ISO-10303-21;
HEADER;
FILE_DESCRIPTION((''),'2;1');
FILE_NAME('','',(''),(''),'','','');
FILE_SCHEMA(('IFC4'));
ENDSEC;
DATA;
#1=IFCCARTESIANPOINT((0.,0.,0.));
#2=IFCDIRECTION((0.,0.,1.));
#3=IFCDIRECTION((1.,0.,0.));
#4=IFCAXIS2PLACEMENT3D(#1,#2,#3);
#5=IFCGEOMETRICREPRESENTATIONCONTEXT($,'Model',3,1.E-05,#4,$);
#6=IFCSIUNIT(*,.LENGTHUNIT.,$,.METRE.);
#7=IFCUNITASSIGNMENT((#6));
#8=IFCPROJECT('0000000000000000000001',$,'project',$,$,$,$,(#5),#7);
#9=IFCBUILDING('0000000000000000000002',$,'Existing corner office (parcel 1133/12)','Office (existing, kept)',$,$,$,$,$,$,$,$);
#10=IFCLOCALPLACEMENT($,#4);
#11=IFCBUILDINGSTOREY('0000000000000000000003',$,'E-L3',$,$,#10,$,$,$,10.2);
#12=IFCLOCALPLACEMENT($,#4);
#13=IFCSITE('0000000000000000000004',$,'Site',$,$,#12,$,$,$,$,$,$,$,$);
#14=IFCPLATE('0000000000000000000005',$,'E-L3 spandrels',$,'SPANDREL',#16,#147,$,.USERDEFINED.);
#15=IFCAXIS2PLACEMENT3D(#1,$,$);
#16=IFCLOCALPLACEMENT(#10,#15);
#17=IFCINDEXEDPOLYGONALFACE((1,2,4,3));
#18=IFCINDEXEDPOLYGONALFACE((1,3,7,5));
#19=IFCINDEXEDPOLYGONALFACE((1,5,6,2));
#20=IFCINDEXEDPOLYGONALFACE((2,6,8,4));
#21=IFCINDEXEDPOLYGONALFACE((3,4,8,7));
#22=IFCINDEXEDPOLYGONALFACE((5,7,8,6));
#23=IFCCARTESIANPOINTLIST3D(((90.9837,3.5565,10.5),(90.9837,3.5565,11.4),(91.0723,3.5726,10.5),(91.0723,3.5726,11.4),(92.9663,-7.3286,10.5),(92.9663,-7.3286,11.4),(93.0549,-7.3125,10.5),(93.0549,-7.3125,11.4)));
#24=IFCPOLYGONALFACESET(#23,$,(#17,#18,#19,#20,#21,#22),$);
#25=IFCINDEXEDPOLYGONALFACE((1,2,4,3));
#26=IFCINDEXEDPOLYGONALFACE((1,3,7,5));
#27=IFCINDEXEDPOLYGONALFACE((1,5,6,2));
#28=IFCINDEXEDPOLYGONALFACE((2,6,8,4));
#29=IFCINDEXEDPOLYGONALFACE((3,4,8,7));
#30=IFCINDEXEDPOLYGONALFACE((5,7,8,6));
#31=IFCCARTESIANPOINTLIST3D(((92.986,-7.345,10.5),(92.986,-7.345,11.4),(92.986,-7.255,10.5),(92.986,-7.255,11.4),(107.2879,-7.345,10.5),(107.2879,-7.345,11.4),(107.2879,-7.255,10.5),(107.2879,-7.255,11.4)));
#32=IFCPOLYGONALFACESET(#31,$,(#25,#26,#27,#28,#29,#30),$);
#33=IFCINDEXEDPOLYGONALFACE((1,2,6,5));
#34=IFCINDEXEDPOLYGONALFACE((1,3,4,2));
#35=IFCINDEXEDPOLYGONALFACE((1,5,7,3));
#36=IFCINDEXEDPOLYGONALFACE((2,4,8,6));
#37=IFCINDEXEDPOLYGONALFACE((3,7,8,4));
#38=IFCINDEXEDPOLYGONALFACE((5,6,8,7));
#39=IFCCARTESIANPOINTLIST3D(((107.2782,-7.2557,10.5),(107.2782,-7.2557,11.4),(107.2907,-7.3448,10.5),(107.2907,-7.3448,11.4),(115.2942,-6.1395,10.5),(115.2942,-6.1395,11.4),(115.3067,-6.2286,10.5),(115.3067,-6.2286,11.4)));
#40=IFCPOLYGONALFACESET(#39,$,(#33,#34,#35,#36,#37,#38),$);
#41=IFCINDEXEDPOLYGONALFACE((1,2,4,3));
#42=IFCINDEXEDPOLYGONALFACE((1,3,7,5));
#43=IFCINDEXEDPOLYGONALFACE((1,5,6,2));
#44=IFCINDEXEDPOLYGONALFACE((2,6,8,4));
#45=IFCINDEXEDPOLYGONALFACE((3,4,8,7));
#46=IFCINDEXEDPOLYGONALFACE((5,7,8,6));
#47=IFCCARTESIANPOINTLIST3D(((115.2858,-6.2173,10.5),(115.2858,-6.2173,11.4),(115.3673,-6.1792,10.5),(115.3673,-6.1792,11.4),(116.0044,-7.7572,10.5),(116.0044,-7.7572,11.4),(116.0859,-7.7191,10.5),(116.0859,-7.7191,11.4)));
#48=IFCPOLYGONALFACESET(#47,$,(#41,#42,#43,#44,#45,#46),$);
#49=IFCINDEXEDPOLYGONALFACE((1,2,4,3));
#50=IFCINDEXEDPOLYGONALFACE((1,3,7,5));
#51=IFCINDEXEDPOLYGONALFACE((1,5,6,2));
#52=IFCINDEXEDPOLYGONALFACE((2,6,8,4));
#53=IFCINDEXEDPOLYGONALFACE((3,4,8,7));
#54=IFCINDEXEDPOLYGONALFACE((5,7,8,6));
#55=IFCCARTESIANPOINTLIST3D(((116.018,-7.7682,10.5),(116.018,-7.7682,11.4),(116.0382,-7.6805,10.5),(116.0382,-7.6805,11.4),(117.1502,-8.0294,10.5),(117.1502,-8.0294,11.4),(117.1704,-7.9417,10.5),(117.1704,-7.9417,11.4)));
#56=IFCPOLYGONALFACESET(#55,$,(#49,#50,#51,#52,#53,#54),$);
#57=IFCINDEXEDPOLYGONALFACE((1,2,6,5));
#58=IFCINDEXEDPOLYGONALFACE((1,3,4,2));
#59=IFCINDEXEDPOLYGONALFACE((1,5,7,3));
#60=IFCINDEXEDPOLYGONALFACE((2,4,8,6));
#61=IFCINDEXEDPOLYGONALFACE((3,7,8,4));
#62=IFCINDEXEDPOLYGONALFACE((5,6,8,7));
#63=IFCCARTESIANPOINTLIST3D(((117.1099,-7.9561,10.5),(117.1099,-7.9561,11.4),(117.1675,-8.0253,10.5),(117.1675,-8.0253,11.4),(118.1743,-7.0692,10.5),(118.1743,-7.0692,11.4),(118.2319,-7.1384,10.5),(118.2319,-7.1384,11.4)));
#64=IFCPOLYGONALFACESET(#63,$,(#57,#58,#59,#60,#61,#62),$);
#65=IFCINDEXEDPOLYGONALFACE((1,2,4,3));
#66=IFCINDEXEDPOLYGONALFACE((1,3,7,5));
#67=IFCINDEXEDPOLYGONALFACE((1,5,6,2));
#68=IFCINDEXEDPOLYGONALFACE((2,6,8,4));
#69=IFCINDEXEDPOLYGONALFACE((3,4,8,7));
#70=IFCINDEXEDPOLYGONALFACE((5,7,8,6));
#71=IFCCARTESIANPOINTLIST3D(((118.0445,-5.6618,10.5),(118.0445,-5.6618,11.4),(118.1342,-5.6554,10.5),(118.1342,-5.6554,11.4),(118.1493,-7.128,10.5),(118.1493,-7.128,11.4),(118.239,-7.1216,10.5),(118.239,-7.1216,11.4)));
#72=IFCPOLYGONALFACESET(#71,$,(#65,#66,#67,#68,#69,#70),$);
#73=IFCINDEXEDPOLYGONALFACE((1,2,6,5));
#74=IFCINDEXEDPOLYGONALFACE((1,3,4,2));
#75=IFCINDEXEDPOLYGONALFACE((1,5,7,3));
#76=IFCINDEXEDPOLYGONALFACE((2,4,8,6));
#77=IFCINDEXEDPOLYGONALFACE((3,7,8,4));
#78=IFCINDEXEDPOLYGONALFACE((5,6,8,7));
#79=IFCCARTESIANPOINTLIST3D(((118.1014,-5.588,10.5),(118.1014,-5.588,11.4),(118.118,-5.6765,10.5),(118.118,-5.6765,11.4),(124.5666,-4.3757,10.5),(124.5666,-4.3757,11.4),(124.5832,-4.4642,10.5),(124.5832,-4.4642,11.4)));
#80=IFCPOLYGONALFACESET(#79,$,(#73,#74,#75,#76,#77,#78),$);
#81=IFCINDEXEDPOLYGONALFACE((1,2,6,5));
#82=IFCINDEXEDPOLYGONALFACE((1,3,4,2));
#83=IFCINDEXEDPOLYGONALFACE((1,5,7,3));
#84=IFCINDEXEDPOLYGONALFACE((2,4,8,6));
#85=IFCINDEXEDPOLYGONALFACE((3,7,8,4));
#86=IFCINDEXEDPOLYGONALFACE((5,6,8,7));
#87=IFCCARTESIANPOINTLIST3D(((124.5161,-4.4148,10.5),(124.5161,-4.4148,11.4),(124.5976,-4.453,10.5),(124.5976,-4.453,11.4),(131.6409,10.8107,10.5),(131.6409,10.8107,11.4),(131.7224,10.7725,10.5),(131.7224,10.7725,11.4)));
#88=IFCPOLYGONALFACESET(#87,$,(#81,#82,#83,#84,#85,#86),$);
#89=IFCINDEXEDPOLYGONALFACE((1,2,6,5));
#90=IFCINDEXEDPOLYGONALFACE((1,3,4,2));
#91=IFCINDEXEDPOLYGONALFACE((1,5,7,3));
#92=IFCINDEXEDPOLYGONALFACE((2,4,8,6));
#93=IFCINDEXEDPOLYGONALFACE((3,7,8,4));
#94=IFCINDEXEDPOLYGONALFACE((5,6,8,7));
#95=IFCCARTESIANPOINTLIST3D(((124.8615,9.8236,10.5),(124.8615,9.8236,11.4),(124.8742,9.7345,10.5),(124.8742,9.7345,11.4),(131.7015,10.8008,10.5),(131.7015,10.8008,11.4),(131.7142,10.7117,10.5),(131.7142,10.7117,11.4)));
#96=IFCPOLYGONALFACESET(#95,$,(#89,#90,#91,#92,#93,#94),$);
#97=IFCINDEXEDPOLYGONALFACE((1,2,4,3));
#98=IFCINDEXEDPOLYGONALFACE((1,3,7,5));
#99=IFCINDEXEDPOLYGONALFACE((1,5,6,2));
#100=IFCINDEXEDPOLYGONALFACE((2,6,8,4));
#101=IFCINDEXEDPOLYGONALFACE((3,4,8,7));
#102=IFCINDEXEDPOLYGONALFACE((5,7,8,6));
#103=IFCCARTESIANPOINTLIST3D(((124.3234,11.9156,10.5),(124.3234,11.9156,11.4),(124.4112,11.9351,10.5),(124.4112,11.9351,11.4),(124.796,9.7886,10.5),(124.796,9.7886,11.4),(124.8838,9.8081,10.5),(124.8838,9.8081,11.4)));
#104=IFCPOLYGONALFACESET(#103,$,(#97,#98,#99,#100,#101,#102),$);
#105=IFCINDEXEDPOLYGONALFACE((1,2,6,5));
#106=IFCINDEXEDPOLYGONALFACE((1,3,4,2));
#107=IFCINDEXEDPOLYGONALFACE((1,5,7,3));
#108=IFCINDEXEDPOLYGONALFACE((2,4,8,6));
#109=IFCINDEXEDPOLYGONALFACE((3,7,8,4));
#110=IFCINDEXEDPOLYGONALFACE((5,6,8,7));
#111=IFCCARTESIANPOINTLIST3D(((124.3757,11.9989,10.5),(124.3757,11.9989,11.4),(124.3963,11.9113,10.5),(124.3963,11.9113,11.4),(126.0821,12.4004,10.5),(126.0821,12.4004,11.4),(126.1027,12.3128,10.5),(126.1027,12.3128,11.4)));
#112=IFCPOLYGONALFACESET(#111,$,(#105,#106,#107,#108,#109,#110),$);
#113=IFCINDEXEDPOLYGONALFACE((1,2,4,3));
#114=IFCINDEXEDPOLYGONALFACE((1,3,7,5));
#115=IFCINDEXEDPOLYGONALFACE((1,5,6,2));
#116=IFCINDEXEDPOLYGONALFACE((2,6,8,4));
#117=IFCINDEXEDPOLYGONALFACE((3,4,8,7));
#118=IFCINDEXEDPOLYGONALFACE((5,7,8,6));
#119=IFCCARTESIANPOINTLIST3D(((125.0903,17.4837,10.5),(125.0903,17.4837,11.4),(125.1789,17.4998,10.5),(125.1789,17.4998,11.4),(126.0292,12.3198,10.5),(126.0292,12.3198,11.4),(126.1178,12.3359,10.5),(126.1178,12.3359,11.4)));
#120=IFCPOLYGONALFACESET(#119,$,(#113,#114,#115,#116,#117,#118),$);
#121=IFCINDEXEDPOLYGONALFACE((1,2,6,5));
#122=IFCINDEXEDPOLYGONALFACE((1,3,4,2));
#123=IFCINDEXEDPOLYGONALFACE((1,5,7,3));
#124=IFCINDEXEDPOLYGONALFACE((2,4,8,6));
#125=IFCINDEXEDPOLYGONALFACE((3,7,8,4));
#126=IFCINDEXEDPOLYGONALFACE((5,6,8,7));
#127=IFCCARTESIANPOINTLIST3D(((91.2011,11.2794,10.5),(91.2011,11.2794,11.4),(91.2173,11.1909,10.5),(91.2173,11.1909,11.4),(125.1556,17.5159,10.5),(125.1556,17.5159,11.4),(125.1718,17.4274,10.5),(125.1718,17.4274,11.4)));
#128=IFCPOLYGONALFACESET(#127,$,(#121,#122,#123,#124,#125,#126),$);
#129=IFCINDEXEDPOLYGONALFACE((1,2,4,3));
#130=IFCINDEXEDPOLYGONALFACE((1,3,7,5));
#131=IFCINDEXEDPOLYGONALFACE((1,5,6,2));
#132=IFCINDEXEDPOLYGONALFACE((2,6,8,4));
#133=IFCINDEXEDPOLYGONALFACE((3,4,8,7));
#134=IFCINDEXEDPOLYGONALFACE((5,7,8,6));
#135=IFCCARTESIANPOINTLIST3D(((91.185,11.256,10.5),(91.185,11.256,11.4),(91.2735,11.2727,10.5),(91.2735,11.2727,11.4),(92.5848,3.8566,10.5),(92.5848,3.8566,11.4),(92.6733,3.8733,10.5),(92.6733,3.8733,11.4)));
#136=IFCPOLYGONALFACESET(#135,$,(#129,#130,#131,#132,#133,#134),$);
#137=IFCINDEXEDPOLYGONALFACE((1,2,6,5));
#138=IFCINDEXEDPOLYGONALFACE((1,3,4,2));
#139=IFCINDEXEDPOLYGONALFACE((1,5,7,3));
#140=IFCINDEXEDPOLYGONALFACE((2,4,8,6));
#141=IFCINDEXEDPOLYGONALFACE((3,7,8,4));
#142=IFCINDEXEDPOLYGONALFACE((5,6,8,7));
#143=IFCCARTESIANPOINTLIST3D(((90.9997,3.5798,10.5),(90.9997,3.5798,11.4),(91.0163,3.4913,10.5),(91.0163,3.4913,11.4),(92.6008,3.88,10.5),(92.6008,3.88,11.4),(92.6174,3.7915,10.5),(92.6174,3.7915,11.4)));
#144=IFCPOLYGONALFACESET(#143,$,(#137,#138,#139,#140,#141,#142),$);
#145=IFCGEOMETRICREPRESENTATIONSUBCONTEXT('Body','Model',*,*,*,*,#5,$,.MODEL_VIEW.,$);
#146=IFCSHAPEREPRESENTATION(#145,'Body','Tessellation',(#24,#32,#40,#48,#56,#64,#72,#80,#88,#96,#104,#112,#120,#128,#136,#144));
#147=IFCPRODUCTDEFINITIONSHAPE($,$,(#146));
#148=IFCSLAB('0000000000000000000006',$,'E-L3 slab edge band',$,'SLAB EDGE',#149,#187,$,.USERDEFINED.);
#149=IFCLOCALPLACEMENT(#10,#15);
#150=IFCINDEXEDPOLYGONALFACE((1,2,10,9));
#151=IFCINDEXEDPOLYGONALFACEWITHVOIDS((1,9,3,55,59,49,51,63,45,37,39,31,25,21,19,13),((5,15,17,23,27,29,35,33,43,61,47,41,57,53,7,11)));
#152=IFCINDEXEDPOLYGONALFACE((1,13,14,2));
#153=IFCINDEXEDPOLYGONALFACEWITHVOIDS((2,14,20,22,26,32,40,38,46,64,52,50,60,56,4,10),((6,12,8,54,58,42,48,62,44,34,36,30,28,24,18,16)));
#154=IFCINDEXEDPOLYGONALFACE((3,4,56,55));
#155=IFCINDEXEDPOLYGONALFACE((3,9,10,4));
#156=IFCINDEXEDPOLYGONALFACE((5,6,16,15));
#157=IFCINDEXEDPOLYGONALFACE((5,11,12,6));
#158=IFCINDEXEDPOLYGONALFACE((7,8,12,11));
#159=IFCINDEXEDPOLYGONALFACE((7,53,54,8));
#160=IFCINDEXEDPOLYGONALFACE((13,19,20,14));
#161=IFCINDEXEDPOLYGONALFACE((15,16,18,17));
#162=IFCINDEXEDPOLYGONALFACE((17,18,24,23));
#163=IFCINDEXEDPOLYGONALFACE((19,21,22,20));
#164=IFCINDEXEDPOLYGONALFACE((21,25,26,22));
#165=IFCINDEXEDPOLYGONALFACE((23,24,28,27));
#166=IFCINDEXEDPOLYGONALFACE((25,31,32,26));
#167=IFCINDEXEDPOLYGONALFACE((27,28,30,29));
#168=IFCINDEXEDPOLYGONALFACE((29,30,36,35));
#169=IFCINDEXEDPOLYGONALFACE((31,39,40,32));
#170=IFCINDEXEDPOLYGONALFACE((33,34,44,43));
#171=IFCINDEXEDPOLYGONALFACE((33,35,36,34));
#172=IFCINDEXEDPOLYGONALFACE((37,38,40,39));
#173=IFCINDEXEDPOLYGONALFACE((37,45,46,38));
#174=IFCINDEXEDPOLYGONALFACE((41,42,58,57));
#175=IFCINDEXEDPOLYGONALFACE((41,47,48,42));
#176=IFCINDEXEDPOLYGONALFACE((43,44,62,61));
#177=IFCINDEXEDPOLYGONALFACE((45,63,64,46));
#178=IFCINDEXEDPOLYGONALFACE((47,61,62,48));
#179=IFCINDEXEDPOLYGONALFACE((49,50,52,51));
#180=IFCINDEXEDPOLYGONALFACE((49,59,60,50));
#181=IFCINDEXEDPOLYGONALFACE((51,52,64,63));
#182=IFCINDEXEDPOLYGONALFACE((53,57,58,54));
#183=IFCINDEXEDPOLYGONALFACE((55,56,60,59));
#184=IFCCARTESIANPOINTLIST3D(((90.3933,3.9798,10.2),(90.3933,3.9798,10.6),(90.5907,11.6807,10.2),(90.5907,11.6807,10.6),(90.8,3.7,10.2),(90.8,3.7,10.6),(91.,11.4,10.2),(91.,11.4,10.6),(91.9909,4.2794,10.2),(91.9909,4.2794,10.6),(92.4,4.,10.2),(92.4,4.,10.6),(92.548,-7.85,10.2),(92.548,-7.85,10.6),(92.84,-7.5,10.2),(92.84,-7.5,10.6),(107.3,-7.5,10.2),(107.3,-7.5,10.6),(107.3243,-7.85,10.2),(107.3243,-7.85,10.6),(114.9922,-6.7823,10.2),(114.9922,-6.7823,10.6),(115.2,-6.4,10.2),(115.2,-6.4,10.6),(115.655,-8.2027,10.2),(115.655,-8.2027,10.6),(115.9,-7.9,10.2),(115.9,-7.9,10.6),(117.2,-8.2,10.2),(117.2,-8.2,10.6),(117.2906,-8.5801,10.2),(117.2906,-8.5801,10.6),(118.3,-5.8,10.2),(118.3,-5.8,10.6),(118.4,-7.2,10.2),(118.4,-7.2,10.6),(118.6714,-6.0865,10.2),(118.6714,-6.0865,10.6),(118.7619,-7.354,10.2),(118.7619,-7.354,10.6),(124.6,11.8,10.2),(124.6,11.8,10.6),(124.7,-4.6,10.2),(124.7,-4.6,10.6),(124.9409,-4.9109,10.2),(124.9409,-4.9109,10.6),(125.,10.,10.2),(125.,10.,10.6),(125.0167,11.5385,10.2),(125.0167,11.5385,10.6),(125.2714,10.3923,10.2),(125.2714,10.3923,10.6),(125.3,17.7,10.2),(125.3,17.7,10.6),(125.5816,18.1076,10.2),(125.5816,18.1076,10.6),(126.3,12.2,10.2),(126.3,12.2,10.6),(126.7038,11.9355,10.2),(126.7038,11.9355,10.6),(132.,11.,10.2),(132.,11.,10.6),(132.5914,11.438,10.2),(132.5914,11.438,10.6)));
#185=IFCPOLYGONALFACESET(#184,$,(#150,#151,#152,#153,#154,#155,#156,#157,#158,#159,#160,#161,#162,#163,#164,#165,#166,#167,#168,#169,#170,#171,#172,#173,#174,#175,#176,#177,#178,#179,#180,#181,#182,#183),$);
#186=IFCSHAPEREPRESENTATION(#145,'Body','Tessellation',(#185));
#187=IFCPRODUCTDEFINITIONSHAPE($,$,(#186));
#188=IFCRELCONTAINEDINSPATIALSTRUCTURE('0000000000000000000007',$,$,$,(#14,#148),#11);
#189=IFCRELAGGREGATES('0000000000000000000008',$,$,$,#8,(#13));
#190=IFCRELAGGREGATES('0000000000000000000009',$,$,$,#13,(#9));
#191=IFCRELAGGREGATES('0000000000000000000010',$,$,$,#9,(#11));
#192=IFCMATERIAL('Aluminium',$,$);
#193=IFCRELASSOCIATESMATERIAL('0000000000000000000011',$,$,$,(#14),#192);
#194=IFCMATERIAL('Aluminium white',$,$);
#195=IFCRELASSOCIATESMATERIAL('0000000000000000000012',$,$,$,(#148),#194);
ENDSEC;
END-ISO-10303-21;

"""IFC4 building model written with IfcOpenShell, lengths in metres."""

from ifc_helpers import new_model, si_unit, frame, origin_with_axes, place, context, subcontext, project, spatial, polyline, outline, extrude, material, element, save


model = new_model("IFC4")

# Units and contexts
model_context = context("Model", 3, precision=1e-05, world=origin_with_axes())
body_context = subcontext(model_context, "Body", "Model", "MODEL_VIEW")
ifc_project = project(units=[si_unit("LENGTHUNIT", "METRE")], contexts=[model_context])

# Site, building, storey
site_placement = place(None, origin_with_axes())
site = spatial("IfcSite", under=ifc_project, at=site_placement, Name="Site")
building = spatial("IfcBuilding", under=site, Name="Existing corner office (parcel 1133/12)", Description="Office (existing, kept)")
storey_placement = place(None, origin_with_axes())
storey = spatial("IfcBuildingStorey", under=building, at=storey_placement, Name="E-L3", Elevation=10.2)

# Shared definitions
ifc_material_1 = material(Name="Aluminium")
ifc_material_2 = material(Name="Aluminium white")

# Plate
plate_placement = place(storey_placement, origin_with_axes())
element("IfcPlate", 1, at=plate_placement, inside=storey, material=ifc_material_1, Name="E-L3 spandrels", ObjectType="SPANDREL", PredefinedType="USERDEFINED", context=body_context, shape_type="SweptSolid", body=[
    extrude(outline(polyline([(90.9837, 3.5565), (92.9663, -7.3286), (93.0549, -7.3125), (91.0723, 3.5726), (90.9837, 3.5565)])), frame((0.0, 0.0, 10.5), z_axis=(0.0, 0.0, 1.0), x_axis=(1.0, 0.0, 0.0)), (0.0, 0.0, 1.0), 0.9),
    extrude(outline(polyline([(92.986, -7.345), (107.2879, -7.345), (107.2879, -7.255), (92.986, -7.255), (92.986, -7.345)])), frame((0.0, 0.0, 10.5), z_axis=(0.0, 0.0, 1.0), x_axis=(1.0, 0.0, 0.0)), (0.0, 0.0, 1.0), 0.9),
    extrude(outline(polyline([(107.2907, -7.3448), (115.3067, -6.2286), (115.2942, -6.1395), (107.2782, -7.2557), (107.2907, -7.3448)])), frame((0.0, 0.0, 10.5), z_axis=(0.0, 0.0, 1.0), x_axis=(1.0, 0.0, 0.0)), (0.0, 0.0, 1.0), 0.9),
    extrude(outline(polyline([(115.2858, -6.2173), (116.0044, -7.7572), (116.0859, -7.7191), (115.3673, -6.1792), (115.2858, -6.2173)])), frame((0.0, 0.0, 10.5), z_axis=(0.0, 0.0, 1.0), x_axis=(1.0, 0.0, 0.0)), (0.0, 0.0, 1.0), 0.9),
    extrude(outline(polyline([(116.018, -7.7682), (117.1502, -8.0294), (117.1704, -7.9417), (116.0382, -7.6805), (116.018, -7.7682)])), frame((0.0, 0.0, 10.5), z_axis=(0.0, 0.0, 1.0), x_axis=(1.0, 0.0, 0.0)), (0.0, 0.0, 1.0), 0.9),
    extrude(outline(polyline([(117.1675, -8.0253), (118.2319, -7.1384), (118.1743, -7.0692), (117.1099, -7.9561), (117.1675, -8.0253)])), frame((0.0, 0.0, 10.5), z_axis=(0.0, 0.0, 1.0), x_axis=(1.0, 0.0, 0.0)), (0.0, 0.0, 1.0), 0.9),
    extrude(outline(polyline([(118.239, -7.1216), (118.1342, -5.6554), (118.0445, -5.6618), (118.1493, -7.128), (118.239, -7.1216)])), frame((0.0, 0.0, 10.5), z_axis=(0.0, 0.0, 1.0), x_axis=(1.0, 0.0, 0.0)), (0.0, 0.0, 1.0), 0.9),
    extrude(outline(polyline([(118.118, -5.6765), (124.5832, -4.4642), (124.5666, -4.3757), (118.1014, -5.588), (118.118, -5.6765)])), frame((0.0, 0.0, 10.5), z_axis=(0.0, 0.0, 1.0), x_axis=(1.0, 0.0, 0.0)), (0.0, 0.0, 1.0), 0.9),
    extrude(outline(polyline([(124.5976, -4.453), (131.7224, 10.7725), (131.6409, 10.8107), (124.5161, -4.4148), (124.5976, -4.453)])), frame((0.0, 0.0, 10.5), z_axis=(0.0, 0.0, 1.0), x_axis=(1.0, 0.0, 0.0)), (0.0, 0.0, 1.0), 0.9),
    extrude(outline(polyline([(131.7015, 10.8008), (124.8615, 9.8236), (124.8742, 9.7345), (131.7142, 10.7117), (131.7015, 10.8008)])), frame((0.0, 0.0, 10.5), z_axis=(0.0, 0.0, 1.0), x_axis=(1.0, 0.0, 0.0)), (0.0, 0.0, 1.0), 0.9),
    extrude(outline(polyline([(124.8838, 9.8081), (124.4112, 11.9351), (124.3234, 11.9156), (124.796, 9.7886), (124.8838, 9.8081)])), frame((0.0, 0.0, 10.5), z_axis=(0.0, 0.0, 1.0), x_axis=(1.0, 0.0, 0.0)), (0.0, 0.0, 1.0), 0.9),
    extrude(outline(polyline([(124.3963, 11.9113), (126.1027, 12.3128), (126.0821, 12.4004), (124.3757, 11.9989), (124.3963, 11.9113)])), frame((0.0, 0.0, 10.5), z_axis=(0.0, 0.0, 1.0), x_axis=(1.0, 0.0, 0.0)), (0.0, 0.0, 1.0), 0.9),
    extrude(outline(polyline([(126.1178, 12.3359), (125.1789, 17.4998), (125.0903, 17.4837), (126.0292, 12.3198), (126.1178, 12.3359)])), frame((0.0, 0.0, 10.5), z_axis=(0.0, 0.0, 1.0), x_axis=(1.0, 0.0, 0.0)), (0.0, 0.0, 1.0), 0.9),
    extrude(outline(polyline([(125.1556, 17.5159), (91.2011, 11.2794), (91.2173, 11.1909), (125.1718, 17.4274), (125.1556, 17.5159)])), frame((0.0, 0.0, 10.5), z_axis=(0.0, 0.0, 1.0), x_axis=(1.0, 0.0, 0.0)), (0.0, 0.0, 1.0), 0.9),
    extrude(outline(polyline([(91.185, 11.256), (92.5848, 3.8566), (92.6733, 3.8733), (91.2735, 11.2727), (91.185, 11.256)])), frame((0.0, 0.0, 10.5), z_axis=(0.0, 0.0, 1.0), x_axis=(1.0, 0.0, 0.0)), (0.0, 0.0, 1.0), 0.9),
    extrude(outline(polyline([(92.6008, 3.88), (90.9997, 3.5798), (91.0163, 3.4913), (92.6174, 3.7915), (92.6008, 3.88)])), frame((0.0, 0.0, 10.5), z_axis=(0.0, 0.0, 1.0), x_axis=(1.0, 0.0, 0.0)), (0.0, 0.0, 1.0), 0.9),
])

# Slab
slab_1_placement = place(storey_placement, origin_with_axes())
element("IfcSlab", 2, at=slab_1_placement, inside=storey, material=ifc_material_2, Name="E-L3 slab edge band", ObjectType="SLAB EDGE", PredefinedType="USERDEFINED", context=body_context, shape_type="SweptSolid", body=[
    extrude(outline(polyline([(90.3933, 3.9798), (92.548, -7.85), (107.3243, -7.85), (114.9922, -6.7823), (115.655, -8.2027), (117.2906, -8.5801), (118.7619, -7.354), (118.6714, -6.0865), (124.9409, -4.9109), (132.5914, 11.438), (125.2714, 10.3923), (125.0167, 11.5385), (126.7038, 11.9355), (125.5816, 18.1076), (90.5907, 11.6807), (91.9909, 4.2794), (90.3933, 3.9798)]), holes=[polyline([(90.8, 3.7), (92.84, -7.5), (107.3, -7.5), (115.2, -6.4), (115.9, -7.9), (117.2, -8.2), (118.4, -7.2), (118.3, -5.8), (124.7, -4.6), (132.0, 11.0), (125.0, 10.0), (124.6, 11.8), (126.3, 12.2), (125.3, 17.7), (91.0, 11.4), (92.4, 4.0), (90.8, 3.7)])]), frame((0.0, 0.0, 10.2), z_axis=(0.0, 0.0, 1.0), x_axis=(1.0, 0.0, 0.0)), (0.0, 0.0, 1.0), 0.4),
])

save(model, "model.ifc")
